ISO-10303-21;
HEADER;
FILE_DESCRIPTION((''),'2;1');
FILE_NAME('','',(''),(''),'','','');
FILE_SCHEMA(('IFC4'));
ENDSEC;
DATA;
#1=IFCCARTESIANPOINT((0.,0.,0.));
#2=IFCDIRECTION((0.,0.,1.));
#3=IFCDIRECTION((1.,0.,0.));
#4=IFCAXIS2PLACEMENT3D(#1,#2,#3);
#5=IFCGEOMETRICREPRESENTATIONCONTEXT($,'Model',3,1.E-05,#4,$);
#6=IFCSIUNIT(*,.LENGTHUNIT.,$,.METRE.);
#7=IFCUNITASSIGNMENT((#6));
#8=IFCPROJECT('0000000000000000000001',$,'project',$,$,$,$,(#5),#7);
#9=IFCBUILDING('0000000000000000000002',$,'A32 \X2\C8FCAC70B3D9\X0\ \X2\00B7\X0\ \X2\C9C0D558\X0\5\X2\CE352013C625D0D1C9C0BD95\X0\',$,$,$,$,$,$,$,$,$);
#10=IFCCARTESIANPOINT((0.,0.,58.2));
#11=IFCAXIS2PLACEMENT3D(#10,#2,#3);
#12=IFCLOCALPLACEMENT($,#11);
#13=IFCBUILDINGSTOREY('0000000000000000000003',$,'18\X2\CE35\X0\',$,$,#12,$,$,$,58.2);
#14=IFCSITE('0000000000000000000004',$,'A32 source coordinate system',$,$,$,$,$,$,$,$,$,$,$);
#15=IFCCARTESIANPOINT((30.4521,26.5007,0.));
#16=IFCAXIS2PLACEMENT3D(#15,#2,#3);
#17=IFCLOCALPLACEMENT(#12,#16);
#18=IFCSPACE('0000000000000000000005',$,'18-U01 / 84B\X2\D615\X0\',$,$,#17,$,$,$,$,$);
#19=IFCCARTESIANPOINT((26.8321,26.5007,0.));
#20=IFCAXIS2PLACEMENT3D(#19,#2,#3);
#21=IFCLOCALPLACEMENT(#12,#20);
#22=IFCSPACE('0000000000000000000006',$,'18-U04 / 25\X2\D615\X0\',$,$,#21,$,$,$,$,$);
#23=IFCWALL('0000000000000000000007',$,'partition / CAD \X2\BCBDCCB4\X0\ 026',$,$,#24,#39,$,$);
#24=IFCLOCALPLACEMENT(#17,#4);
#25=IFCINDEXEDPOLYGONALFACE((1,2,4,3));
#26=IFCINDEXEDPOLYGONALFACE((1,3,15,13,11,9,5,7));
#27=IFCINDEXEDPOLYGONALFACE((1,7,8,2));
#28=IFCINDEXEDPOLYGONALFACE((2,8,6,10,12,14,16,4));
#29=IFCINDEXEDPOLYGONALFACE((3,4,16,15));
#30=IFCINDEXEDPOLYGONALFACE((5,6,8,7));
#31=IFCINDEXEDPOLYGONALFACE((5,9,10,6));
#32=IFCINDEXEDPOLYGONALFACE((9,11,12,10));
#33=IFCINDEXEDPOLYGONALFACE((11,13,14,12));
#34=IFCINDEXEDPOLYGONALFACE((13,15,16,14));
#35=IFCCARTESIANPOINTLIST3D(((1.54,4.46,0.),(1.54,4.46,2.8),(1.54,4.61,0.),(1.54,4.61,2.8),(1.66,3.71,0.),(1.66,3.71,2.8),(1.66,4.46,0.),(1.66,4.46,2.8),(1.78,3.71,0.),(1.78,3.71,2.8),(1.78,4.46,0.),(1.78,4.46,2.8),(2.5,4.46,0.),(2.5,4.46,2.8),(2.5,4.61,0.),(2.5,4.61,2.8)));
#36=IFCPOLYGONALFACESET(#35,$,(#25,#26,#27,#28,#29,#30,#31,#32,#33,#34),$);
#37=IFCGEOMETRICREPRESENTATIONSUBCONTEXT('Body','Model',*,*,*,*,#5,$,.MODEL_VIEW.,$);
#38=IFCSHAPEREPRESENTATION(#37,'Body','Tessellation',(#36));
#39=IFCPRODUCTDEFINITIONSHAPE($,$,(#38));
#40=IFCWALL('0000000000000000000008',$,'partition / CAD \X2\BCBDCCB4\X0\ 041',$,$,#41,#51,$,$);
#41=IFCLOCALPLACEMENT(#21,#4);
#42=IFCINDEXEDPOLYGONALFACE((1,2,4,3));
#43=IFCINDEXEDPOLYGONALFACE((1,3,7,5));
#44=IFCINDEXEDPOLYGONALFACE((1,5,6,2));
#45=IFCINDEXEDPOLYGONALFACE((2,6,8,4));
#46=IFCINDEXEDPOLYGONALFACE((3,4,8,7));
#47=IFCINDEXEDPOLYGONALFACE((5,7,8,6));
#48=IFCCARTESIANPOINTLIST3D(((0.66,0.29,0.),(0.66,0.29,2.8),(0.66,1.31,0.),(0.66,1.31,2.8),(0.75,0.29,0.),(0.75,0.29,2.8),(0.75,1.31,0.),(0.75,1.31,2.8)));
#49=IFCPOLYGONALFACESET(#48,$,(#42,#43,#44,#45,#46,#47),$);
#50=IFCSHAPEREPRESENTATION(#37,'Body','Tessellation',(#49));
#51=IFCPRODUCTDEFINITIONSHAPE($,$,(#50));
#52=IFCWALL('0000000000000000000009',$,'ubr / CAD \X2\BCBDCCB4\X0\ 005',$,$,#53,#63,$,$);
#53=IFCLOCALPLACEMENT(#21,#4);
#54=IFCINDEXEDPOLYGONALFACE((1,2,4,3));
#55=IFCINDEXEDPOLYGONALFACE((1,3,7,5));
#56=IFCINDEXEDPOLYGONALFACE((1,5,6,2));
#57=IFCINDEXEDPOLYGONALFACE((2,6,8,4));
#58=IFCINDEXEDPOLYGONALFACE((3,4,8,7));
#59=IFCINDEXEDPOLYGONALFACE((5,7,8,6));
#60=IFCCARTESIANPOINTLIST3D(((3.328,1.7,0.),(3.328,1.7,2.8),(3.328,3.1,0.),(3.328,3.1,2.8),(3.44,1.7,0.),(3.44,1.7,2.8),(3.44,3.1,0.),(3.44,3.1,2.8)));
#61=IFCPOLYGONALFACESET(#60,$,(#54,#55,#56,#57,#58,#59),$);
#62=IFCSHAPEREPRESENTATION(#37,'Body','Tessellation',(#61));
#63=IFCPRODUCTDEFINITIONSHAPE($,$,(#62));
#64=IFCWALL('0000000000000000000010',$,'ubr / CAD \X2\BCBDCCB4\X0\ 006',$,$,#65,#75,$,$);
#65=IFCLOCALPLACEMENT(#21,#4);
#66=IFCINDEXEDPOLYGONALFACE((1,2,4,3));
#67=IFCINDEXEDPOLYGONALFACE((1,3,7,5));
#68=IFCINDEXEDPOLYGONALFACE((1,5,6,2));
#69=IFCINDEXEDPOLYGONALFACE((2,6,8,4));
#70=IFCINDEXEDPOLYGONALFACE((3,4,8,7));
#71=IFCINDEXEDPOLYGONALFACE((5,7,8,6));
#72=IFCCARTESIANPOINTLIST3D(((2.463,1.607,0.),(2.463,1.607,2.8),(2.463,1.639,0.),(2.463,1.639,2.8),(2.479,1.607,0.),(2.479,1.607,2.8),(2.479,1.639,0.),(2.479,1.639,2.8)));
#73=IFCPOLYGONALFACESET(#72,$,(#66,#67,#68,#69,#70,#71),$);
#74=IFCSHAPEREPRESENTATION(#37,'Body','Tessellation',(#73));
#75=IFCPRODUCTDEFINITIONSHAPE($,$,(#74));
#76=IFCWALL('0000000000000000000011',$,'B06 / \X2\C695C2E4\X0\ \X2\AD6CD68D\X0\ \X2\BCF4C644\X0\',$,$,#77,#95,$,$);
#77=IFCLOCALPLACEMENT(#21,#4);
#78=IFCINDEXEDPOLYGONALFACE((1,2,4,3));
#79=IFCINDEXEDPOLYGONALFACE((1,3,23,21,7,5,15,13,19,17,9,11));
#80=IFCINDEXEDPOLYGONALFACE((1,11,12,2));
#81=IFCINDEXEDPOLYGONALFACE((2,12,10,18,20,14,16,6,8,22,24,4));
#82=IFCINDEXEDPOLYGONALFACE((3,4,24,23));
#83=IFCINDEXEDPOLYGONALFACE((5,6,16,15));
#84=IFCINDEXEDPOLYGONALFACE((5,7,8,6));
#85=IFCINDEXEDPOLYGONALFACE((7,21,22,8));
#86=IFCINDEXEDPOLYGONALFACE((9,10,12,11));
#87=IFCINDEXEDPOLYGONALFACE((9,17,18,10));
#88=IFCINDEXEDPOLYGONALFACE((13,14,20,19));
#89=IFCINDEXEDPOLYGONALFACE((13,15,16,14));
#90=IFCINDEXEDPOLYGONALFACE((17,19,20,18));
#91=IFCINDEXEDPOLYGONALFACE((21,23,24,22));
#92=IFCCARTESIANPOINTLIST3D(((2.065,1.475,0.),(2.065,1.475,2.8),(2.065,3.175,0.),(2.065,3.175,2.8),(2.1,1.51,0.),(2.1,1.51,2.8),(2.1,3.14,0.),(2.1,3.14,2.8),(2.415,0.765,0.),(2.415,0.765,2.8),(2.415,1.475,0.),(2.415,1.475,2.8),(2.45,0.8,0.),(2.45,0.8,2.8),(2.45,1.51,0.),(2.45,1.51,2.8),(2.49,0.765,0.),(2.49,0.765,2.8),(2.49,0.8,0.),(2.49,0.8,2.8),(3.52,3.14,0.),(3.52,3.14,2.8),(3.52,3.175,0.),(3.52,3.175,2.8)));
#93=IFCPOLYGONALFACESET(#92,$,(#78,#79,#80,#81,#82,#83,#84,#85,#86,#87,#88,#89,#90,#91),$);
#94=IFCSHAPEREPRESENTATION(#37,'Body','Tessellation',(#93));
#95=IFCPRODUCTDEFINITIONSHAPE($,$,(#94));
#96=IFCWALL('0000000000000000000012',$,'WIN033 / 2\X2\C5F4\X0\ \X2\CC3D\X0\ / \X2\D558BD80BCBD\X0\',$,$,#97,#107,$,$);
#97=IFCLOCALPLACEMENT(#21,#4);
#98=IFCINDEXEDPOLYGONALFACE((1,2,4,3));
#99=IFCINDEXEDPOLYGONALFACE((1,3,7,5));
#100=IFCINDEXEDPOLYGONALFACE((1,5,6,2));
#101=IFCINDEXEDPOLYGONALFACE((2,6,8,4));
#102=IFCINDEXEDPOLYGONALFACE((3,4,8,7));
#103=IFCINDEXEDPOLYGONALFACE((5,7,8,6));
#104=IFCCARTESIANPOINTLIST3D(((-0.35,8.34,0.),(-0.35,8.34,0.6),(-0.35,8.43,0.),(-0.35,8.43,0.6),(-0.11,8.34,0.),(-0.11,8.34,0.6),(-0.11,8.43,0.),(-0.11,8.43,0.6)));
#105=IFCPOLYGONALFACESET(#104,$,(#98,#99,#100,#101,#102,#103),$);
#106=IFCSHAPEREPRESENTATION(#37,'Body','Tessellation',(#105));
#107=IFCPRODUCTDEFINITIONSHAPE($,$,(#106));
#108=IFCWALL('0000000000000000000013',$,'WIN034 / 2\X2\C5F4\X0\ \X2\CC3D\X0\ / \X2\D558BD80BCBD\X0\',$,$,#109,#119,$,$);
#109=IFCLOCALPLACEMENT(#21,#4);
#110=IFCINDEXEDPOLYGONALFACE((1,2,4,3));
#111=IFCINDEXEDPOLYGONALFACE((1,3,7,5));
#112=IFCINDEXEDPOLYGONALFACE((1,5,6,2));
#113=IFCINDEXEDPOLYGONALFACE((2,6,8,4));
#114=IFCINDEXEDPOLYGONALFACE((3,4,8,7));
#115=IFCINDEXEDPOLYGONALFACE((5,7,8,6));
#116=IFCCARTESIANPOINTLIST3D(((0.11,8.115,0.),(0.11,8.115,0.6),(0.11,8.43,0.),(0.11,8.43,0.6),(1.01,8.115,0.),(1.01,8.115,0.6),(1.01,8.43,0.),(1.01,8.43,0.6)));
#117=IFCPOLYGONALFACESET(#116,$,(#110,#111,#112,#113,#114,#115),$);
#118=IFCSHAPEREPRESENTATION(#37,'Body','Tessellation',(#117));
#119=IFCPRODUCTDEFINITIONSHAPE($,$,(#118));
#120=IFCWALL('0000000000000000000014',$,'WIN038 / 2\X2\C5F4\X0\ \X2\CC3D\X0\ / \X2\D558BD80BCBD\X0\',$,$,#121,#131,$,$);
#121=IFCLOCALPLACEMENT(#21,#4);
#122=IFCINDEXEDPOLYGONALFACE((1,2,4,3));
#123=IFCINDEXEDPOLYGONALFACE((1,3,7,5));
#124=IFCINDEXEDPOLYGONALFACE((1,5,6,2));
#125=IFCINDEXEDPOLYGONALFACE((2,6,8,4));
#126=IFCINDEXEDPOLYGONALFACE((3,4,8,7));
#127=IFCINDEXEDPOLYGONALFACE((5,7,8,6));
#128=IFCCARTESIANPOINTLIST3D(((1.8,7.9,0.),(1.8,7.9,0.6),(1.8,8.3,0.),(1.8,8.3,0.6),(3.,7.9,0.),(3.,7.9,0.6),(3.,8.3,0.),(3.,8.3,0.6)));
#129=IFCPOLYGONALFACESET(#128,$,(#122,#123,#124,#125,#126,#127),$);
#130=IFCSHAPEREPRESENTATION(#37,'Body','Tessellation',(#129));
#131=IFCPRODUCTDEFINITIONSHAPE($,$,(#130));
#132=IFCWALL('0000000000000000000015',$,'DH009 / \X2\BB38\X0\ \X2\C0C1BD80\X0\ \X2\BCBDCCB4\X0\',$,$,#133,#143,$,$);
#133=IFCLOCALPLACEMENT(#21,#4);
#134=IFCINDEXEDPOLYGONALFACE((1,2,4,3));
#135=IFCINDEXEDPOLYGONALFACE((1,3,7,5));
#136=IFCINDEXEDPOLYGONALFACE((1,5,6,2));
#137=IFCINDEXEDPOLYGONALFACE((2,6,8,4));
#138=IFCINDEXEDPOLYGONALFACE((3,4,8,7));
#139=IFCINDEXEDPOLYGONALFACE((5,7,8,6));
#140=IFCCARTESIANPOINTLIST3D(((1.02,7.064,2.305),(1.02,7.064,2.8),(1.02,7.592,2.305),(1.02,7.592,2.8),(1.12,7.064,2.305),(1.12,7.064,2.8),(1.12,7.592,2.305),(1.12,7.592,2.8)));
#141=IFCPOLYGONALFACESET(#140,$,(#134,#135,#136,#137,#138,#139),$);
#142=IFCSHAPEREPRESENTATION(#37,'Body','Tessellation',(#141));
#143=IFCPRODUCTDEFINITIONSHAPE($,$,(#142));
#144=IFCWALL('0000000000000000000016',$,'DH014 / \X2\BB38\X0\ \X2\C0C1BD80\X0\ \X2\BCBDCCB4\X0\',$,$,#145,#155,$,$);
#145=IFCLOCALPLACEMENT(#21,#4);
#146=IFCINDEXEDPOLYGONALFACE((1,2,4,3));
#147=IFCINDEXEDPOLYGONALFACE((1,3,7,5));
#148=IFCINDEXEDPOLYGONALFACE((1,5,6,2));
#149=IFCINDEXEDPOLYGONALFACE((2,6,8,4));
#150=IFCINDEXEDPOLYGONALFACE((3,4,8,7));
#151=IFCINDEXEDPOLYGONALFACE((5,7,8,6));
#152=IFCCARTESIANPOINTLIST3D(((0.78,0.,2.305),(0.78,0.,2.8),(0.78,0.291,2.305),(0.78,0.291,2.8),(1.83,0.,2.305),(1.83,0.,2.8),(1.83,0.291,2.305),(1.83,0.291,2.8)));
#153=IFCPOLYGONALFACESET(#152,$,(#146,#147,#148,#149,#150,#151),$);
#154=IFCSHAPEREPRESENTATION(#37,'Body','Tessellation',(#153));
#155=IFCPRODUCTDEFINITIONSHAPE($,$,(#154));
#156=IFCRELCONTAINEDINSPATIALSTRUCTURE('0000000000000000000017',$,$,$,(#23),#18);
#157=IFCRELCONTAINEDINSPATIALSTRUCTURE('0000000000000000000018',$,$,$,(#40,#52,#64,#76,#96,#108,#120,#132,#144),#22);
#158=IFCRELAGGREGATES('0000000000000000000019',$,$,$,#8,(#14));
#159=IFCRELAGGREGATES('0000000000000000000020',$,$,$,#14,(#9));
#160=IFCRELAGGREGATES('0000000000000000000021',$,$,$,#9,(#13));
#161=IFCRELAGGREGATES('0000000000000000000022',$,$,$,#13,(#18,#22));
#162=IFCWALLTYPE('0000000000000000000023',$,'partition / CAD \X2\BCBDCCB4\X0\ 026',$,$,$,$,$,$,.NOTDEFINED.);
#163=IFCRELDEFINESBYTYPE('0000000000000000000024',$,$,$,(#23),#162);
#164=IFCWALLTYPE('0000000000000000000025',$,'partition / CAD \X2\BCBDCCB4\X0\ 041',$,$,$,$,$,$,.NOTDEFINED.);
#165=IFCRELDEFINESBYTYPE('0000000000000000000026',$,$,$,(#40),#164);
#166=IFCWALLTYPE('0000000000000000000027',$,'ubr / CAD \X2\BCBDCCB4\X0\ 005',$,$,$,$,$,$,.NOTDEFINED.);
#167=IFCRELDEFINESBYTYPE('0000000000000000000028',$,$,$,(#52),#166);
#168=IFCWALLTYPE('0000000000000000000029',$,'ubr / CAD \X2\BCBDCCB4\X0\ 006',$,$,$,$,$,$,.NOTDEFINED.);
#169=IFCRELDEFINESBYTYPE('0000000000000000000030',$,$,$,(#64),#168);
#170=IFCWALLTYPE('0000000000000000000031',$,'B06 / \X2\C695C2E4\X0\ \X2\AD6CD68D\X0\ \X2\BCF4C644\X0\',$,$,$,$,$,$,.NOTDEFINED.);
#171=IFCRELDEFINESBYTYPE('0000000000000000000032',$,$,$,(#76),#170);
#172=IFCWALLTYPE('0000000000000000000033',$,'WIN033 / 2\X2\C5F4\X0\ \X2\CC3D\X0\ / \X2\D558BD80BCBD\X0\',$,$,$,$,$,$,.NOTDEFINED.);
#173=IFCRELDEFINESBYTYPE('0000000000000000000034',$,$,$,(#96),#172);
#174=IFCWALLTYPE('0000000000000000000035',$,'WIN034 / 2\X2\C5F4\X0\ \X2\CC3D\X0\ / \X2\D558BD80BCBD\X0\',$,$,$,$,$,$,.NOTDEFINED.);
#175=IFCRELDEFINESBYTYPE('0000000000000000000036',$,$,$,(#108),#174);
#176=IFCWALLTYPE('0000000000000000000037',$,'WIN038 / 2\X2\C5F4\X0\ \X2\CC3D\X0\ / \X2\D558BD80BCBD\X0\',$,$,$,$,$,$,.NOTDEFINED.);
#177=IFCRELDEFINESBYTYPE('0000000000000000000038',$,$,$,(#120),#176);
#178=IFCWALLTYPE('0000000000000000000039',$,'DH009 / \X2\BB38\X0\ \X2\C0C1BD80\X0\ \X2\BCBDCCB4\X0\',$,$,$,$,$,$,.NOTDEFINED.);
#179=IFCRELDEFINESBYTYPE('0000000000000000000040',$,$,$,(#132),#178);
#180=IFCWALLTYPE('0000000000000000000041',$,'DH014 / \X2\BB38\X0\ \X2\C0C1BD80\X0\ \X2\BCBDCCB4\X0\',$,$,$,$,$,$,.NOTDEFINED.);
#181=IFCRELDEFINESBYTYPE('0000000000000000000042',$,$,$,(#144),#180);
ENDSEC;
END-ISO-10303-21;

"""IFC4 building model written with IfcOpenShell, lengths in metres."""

from ifc_helpers import new_model, si_unit, frame, origin, origin_with_axes, place, context, subcontext, project, spatial, polyline, outline, extrude, source, transform, mapped, type_object, type_shapes, element, save


model = new_model("IFC4")

# Units and contexts
model_context = context("Model", 3, precision=1e-05, world=origin_with_axes())
body_context = subcontext(model_context, "Body", "Model", "MODEL_VIEW")
ifc_project = project(units=[si_unit("LENGTHUNIT", "METRE")], contexts=[model_context])

# Site, building, storey, space
site = spatial("IfcSite", under=ifc_project, Name="A32 source coordinate system")
building = spatial("IfcBuilding", under=site, Name="A32 주거동 · 지하5층–옥탑지붕")
storey_placement = place(None, frame((0.0, 0.0, 58.2), z_axis=(0.0, 0.0, 1.0), x_axis=(1.0, 0.0, 0.0)))
storey = spatial("IfcBuildingStorey", under=building, at=storey_placement, Name="18층", Elevation=58.2)
space_1_placement = place(storey_placement, frame((30.4521, 26.5007, 0.0), z_axis=(0.0, 0.0, 1.0), x_axis=(1.0, 0.0, 0.0)))
space_1 = spatial("IfcSpace", under=storey, at=space_1_placement, Name="18-U01 / 84B형")

# Wall
wall_type_1 = type_object("IfcWallType", Name="partition / CAD 벽체 026", PredefinedType="NOTDEFINED")
shared_shape_1 = source(origin(), body_context, "Body", "SweptSolid", [
    extrude(outline(polyline([(1.54, 4.46), (1.54, 4.61), (2.5, 4.61), (2.5, 4.46), (1.78, 4.46), (1.78, 3.71), (1.66, 3.71), (1.66, 4.46), (1.54, 4.46)])), origin(), (0.0, 0.0, 1.0), 2.8),
])
type_shapes(wall_type_1, [shared_shape_1])
wall_1_placement = place(space_1_placement, origin_with_axes())
element("IfcWall", 1, at=wall_1_placement, inside=space_1, type_object=wall_type_1, Name="partition / CAD 벽체 026", context=body_context, shape_type="MappedRepresentation", body=[
    mapped(shared_shape_1, transform((0.0, 0.0, 0.0), scale=1.0)),
])

# Shared definitions
space_2_placement = place(storey_placement, frame((26.8321, 26.5007, 0.0), z_axis=(0.0, 0.0, 1.0), x_axis=(1.0, 0.0, 0.0)))
space_2 = spatial("IfcSpace", under=storey, at=space_2_placement, Name="18-U04 / 25형")

# Walls
wall_type_2 = type_object("IfcWallType", Name="partition / CAD 벽체 041", PredefinedType="NOTDEFINED")
shared_shape_2 = source(origin(), body_context, "Body", "SweptSolid", [
    extrude(outline(polyline([(0.75, 1.31), (0.75, 0.29), (0.66, 0.29), (0.66, 1.31), (0.75, 1.31)])), origin(), (0.0, 0.0, 1.0), 2.8),
])
type_shapes(wall_type_2, [shared_shape_2])
wall_2_placement = place(space_2_placement, origin_with_axes())
element("IfcWall", 2, at=wall_2_placement, inside=space_2, type_object=wall_type_2, Name="partition / CAD 벽체 041", context=body_context, shape_type="MappedRepresentation", body=[
    mapped(shared_shape_2, transform((0.0, 0.0, 0.0), scale=1.0)),
])
wall_type_3 = type_object("IfcWallType", Name="ubr / CAD 벽체 005", PredefinedType="NOTDEFINED")
shared_shape_3 = source(origin(), body_context, "Body", "SweptSolid", [
    extrude(outline(polyline([(3.44, 3.1), (3.44, 1.7), (3.328, 1.7), (3.328, 3.1), (3.44, 3.1)])), origin(), (0.0, 0.0, 1.0), 2.8),
])
type_shapes(wall_type_3, [shared_shape_3])
wall_3_placement = place(space_2_placement, origin_with_axes())
element("IfcWall", 3, at=wall_3_placement, inside=space_2, type_object=wall_type_3, Name="ubr / CAD 벽체 005", context=body_context, shape_type="MappedRepresentation", body=[
    mapped(shared_shape_3, transform((0.0, 0.0, 0.0), scale=1.0)),
])
wall_type_4 = type_object("IfcWallType", Name="ubr / CAD 벽체 006", PredefinedType="NOTDEFINED")
shared_shape_4 = source(origin(), body_context, "Body", "SweptSolid", [
    extrude(outline(polyline([(2.463, 1.639), (2.479, 1.639), (2.479, 1.607), (2.463, 1.607), (2.463, 1.639)])), origin(), (0.0, 0.0, 1.0), 2.8),
])
type_shapes(wall_type_4, [shared_shape_4])
wall_4_placement = place(space_2_placement, origin_with_axes())
element("IfcWall", 4, at=wall_4_placement, inside=space_2, type_object=wall_type_4, Name="ubr / CAD 벽체 006", context=body_context, shape_type="MappedRepresentation", body=[
    mapped(shared_shape_4, transform((0.0, 0.0, 0.0), scale=1.0)),
])
wall_type_5 = type_object("IfcWallType", Name="B06 / 욕실 구획 보완", PredefinedType="NOTDEFINED")
shared_shape_5 = source(origin(), body_context, "Body", "SweptSolid", [
    extrude(outline(polyline([(3.52, 3.14), (2.1, 3.14), (2.1, 1.51), (2.45, 1.51), (2.45, 0.8), (2.49, 0.8), (2.49, 0.765), (2.415, 0.765), (2.415, 1.475), (2.065, 1.475), (2.065, 3.175), (3.52, 3.175), (3.52, 3.14)])), origin(), (0.0, 0.0, 1.0), 2.8),
])
type_shapes(wall_type_5, [shared_shape_5])
wall_5_placement = place(space_2_placement, origin_with_axes())
element("IfcWall", 5, at=wall_5_placement, inside=space_2, type_object=wall_type_5, Name="B06 / 욕실 구획 보완", context=body_context, shape_type="MappedRepresentation", body=[
    mapped(shared_shape_5, transform((0.0, 0.0, 0.0), scale=1.0)),
])
wall_type_6 = type_object("IfcWallType", Name="WIN033 / 2열 창 / 하부벽", PredefinedType="NOTDEFINED")
shared_shape_6 = source(origin(), body_context, "Body", "SweptSolid", [
    extrude(outline(polyline([(-0.11, 8.43), (-0.11, 8.34), (-0.35, 8.34), (-0.35, 8.43), (-0.11, 8.43)])), origin(), (0.0, 0.0, 1.0), 0.6),
])
type_shapes(wall_type_6, [shared_shape_6])
wall_6_placement = place(space_2_placement, origin_with_axes())
element("IfcWall", 6, at=wall_6_placement, inside=space_2, type_object=wall_type_6, Name="WIN033 / 2열 창 / 하부벽", context=body_context, shape_type="MappedRepresentation", body=[
    mapped(shared_shape_6, transform((0.0, 0.0, 0.0), scale=1.0)),
])
wall_type_7 = type_object("IfcWallType", Name="WIN034 / 2열 창 / 하부벽", PredefinedType="NOTDEFINED")
shared_shape_7 = source(origin(), body_context, "Body", "SweptSolid", [
    extrude(outline(polyline([(0.11, 8.115), (0.11, 8.43), (1.01, 8.43), (1.01, 8.115), (0.11, 8.115)])), origin(), (0.0, 0.0, 1.0), 0.6),
])
type_shapes(wall_type_7, [shared_shape_7])
wall_7_placement = place(space_2_placement, origin_with_axes())
element("IfcWall", 7, at=wall_7_placement, inside=space_2, type_object=wall_type_7, Name="WIN034 / 2열 창 / 하부벽", context=body_context, shape_type="MappedRepresentation", body=[
    mapped(shared_shape_7, transform((0.0, 0.0, 0.0), scale=1.0)),
])
wall_type_8 = type_object("IfcWallType", Name="WIN038 / 2열 창 / 하부벽", PredefinedType="NOTDEFINED")
shared_shape_8 = source(origin(), body_context, "Body", "SweptSolid", [
    extrude(outline(polyline([(1.8, 7.9), (1.8, 8.3), (3.0, 8.3), (3.0, 7.9), (1.8, 7.9)])), origin(), (0.0, 0.0, 1.0), 0.6),
])
type_shapes(wall_type_8, [shared_shape_8])
wall_8_placement = place(space_2_placement, origin_with_axes())
element("IfcWall", 8, at=wall_8_placement, inside=space_2, type_object=wall_type_8, Name="WIN038 / 2열 창 / 하부벽", context=body_context, shape_type="MappedRepresentation", body=[
    mapped(shared_shape_8, transform((0.0, 0.0, 0.0), scale=1.0)),
])
wall_type_9 = type_object("IfcWallType", Name="DH009 / 문 상부 벽체", PredefinedType="NOTDEFINED")
shared_shape_9 = source(origin(), body_context, "Body", "SweptSolid", [
    extrude(outline(polyline([(1.02, 7.064), (1.02, 7.592), (1.12, 7.592), (1.12, 7.064), (1.02, 7.064)])), frame((0.0, 0.0, 2.305)), (0.0, 0.0, 1.0), 0.495),
])
type_shapes(wall_type_9, [shared_shape_9])
wall_9_placement = place(space_2_placement, origin_with_axes())
element("IfcWall", 9, at=wall_9_placement, inside=space_2, type_object=wall_type_9, Name="DH009 / 문 상부 벽체", context=body_context, shape_type="MappedRepresentation", body=[
    mapped(shared_shape_9, transform((0.0, 0.0, 0.0), scale=1.0)),
])
wall_type_10 = type_object("IfcWallType", Name="DH014 / 문 상부 벽체", PredefinedType="NOTDEFINED")
shared_shape_10 = source(origin(), body_context, "Body", "SweptSolid", [
    extrude(outline(polyline([(0.78, 0.291), (1.83, 0.291), (1.83, 0.0), (0.78, 0.0), (0.78, 0.291)])), frame((0.0, 0.0, 2.305)), (0.0, 0.0, 1.0), 0.495),
])
type_shapes(wall_type_10, [shared_shape_10])
wall_10_placement = place(space_2_placement, origin_with_axes())
element("IfcWall", 10, at=wall_10_placement, inside=space_2, type_object=wall_type_10, Name="DH014 / 문 상부 벽체", context=body_context, shape_type="MappedRepresentation", body=[
    mapped(shared_shape_10, transform((0.0, 0.0, 0.0), scale=1.0)),
])

save(model, "model.ifc")
